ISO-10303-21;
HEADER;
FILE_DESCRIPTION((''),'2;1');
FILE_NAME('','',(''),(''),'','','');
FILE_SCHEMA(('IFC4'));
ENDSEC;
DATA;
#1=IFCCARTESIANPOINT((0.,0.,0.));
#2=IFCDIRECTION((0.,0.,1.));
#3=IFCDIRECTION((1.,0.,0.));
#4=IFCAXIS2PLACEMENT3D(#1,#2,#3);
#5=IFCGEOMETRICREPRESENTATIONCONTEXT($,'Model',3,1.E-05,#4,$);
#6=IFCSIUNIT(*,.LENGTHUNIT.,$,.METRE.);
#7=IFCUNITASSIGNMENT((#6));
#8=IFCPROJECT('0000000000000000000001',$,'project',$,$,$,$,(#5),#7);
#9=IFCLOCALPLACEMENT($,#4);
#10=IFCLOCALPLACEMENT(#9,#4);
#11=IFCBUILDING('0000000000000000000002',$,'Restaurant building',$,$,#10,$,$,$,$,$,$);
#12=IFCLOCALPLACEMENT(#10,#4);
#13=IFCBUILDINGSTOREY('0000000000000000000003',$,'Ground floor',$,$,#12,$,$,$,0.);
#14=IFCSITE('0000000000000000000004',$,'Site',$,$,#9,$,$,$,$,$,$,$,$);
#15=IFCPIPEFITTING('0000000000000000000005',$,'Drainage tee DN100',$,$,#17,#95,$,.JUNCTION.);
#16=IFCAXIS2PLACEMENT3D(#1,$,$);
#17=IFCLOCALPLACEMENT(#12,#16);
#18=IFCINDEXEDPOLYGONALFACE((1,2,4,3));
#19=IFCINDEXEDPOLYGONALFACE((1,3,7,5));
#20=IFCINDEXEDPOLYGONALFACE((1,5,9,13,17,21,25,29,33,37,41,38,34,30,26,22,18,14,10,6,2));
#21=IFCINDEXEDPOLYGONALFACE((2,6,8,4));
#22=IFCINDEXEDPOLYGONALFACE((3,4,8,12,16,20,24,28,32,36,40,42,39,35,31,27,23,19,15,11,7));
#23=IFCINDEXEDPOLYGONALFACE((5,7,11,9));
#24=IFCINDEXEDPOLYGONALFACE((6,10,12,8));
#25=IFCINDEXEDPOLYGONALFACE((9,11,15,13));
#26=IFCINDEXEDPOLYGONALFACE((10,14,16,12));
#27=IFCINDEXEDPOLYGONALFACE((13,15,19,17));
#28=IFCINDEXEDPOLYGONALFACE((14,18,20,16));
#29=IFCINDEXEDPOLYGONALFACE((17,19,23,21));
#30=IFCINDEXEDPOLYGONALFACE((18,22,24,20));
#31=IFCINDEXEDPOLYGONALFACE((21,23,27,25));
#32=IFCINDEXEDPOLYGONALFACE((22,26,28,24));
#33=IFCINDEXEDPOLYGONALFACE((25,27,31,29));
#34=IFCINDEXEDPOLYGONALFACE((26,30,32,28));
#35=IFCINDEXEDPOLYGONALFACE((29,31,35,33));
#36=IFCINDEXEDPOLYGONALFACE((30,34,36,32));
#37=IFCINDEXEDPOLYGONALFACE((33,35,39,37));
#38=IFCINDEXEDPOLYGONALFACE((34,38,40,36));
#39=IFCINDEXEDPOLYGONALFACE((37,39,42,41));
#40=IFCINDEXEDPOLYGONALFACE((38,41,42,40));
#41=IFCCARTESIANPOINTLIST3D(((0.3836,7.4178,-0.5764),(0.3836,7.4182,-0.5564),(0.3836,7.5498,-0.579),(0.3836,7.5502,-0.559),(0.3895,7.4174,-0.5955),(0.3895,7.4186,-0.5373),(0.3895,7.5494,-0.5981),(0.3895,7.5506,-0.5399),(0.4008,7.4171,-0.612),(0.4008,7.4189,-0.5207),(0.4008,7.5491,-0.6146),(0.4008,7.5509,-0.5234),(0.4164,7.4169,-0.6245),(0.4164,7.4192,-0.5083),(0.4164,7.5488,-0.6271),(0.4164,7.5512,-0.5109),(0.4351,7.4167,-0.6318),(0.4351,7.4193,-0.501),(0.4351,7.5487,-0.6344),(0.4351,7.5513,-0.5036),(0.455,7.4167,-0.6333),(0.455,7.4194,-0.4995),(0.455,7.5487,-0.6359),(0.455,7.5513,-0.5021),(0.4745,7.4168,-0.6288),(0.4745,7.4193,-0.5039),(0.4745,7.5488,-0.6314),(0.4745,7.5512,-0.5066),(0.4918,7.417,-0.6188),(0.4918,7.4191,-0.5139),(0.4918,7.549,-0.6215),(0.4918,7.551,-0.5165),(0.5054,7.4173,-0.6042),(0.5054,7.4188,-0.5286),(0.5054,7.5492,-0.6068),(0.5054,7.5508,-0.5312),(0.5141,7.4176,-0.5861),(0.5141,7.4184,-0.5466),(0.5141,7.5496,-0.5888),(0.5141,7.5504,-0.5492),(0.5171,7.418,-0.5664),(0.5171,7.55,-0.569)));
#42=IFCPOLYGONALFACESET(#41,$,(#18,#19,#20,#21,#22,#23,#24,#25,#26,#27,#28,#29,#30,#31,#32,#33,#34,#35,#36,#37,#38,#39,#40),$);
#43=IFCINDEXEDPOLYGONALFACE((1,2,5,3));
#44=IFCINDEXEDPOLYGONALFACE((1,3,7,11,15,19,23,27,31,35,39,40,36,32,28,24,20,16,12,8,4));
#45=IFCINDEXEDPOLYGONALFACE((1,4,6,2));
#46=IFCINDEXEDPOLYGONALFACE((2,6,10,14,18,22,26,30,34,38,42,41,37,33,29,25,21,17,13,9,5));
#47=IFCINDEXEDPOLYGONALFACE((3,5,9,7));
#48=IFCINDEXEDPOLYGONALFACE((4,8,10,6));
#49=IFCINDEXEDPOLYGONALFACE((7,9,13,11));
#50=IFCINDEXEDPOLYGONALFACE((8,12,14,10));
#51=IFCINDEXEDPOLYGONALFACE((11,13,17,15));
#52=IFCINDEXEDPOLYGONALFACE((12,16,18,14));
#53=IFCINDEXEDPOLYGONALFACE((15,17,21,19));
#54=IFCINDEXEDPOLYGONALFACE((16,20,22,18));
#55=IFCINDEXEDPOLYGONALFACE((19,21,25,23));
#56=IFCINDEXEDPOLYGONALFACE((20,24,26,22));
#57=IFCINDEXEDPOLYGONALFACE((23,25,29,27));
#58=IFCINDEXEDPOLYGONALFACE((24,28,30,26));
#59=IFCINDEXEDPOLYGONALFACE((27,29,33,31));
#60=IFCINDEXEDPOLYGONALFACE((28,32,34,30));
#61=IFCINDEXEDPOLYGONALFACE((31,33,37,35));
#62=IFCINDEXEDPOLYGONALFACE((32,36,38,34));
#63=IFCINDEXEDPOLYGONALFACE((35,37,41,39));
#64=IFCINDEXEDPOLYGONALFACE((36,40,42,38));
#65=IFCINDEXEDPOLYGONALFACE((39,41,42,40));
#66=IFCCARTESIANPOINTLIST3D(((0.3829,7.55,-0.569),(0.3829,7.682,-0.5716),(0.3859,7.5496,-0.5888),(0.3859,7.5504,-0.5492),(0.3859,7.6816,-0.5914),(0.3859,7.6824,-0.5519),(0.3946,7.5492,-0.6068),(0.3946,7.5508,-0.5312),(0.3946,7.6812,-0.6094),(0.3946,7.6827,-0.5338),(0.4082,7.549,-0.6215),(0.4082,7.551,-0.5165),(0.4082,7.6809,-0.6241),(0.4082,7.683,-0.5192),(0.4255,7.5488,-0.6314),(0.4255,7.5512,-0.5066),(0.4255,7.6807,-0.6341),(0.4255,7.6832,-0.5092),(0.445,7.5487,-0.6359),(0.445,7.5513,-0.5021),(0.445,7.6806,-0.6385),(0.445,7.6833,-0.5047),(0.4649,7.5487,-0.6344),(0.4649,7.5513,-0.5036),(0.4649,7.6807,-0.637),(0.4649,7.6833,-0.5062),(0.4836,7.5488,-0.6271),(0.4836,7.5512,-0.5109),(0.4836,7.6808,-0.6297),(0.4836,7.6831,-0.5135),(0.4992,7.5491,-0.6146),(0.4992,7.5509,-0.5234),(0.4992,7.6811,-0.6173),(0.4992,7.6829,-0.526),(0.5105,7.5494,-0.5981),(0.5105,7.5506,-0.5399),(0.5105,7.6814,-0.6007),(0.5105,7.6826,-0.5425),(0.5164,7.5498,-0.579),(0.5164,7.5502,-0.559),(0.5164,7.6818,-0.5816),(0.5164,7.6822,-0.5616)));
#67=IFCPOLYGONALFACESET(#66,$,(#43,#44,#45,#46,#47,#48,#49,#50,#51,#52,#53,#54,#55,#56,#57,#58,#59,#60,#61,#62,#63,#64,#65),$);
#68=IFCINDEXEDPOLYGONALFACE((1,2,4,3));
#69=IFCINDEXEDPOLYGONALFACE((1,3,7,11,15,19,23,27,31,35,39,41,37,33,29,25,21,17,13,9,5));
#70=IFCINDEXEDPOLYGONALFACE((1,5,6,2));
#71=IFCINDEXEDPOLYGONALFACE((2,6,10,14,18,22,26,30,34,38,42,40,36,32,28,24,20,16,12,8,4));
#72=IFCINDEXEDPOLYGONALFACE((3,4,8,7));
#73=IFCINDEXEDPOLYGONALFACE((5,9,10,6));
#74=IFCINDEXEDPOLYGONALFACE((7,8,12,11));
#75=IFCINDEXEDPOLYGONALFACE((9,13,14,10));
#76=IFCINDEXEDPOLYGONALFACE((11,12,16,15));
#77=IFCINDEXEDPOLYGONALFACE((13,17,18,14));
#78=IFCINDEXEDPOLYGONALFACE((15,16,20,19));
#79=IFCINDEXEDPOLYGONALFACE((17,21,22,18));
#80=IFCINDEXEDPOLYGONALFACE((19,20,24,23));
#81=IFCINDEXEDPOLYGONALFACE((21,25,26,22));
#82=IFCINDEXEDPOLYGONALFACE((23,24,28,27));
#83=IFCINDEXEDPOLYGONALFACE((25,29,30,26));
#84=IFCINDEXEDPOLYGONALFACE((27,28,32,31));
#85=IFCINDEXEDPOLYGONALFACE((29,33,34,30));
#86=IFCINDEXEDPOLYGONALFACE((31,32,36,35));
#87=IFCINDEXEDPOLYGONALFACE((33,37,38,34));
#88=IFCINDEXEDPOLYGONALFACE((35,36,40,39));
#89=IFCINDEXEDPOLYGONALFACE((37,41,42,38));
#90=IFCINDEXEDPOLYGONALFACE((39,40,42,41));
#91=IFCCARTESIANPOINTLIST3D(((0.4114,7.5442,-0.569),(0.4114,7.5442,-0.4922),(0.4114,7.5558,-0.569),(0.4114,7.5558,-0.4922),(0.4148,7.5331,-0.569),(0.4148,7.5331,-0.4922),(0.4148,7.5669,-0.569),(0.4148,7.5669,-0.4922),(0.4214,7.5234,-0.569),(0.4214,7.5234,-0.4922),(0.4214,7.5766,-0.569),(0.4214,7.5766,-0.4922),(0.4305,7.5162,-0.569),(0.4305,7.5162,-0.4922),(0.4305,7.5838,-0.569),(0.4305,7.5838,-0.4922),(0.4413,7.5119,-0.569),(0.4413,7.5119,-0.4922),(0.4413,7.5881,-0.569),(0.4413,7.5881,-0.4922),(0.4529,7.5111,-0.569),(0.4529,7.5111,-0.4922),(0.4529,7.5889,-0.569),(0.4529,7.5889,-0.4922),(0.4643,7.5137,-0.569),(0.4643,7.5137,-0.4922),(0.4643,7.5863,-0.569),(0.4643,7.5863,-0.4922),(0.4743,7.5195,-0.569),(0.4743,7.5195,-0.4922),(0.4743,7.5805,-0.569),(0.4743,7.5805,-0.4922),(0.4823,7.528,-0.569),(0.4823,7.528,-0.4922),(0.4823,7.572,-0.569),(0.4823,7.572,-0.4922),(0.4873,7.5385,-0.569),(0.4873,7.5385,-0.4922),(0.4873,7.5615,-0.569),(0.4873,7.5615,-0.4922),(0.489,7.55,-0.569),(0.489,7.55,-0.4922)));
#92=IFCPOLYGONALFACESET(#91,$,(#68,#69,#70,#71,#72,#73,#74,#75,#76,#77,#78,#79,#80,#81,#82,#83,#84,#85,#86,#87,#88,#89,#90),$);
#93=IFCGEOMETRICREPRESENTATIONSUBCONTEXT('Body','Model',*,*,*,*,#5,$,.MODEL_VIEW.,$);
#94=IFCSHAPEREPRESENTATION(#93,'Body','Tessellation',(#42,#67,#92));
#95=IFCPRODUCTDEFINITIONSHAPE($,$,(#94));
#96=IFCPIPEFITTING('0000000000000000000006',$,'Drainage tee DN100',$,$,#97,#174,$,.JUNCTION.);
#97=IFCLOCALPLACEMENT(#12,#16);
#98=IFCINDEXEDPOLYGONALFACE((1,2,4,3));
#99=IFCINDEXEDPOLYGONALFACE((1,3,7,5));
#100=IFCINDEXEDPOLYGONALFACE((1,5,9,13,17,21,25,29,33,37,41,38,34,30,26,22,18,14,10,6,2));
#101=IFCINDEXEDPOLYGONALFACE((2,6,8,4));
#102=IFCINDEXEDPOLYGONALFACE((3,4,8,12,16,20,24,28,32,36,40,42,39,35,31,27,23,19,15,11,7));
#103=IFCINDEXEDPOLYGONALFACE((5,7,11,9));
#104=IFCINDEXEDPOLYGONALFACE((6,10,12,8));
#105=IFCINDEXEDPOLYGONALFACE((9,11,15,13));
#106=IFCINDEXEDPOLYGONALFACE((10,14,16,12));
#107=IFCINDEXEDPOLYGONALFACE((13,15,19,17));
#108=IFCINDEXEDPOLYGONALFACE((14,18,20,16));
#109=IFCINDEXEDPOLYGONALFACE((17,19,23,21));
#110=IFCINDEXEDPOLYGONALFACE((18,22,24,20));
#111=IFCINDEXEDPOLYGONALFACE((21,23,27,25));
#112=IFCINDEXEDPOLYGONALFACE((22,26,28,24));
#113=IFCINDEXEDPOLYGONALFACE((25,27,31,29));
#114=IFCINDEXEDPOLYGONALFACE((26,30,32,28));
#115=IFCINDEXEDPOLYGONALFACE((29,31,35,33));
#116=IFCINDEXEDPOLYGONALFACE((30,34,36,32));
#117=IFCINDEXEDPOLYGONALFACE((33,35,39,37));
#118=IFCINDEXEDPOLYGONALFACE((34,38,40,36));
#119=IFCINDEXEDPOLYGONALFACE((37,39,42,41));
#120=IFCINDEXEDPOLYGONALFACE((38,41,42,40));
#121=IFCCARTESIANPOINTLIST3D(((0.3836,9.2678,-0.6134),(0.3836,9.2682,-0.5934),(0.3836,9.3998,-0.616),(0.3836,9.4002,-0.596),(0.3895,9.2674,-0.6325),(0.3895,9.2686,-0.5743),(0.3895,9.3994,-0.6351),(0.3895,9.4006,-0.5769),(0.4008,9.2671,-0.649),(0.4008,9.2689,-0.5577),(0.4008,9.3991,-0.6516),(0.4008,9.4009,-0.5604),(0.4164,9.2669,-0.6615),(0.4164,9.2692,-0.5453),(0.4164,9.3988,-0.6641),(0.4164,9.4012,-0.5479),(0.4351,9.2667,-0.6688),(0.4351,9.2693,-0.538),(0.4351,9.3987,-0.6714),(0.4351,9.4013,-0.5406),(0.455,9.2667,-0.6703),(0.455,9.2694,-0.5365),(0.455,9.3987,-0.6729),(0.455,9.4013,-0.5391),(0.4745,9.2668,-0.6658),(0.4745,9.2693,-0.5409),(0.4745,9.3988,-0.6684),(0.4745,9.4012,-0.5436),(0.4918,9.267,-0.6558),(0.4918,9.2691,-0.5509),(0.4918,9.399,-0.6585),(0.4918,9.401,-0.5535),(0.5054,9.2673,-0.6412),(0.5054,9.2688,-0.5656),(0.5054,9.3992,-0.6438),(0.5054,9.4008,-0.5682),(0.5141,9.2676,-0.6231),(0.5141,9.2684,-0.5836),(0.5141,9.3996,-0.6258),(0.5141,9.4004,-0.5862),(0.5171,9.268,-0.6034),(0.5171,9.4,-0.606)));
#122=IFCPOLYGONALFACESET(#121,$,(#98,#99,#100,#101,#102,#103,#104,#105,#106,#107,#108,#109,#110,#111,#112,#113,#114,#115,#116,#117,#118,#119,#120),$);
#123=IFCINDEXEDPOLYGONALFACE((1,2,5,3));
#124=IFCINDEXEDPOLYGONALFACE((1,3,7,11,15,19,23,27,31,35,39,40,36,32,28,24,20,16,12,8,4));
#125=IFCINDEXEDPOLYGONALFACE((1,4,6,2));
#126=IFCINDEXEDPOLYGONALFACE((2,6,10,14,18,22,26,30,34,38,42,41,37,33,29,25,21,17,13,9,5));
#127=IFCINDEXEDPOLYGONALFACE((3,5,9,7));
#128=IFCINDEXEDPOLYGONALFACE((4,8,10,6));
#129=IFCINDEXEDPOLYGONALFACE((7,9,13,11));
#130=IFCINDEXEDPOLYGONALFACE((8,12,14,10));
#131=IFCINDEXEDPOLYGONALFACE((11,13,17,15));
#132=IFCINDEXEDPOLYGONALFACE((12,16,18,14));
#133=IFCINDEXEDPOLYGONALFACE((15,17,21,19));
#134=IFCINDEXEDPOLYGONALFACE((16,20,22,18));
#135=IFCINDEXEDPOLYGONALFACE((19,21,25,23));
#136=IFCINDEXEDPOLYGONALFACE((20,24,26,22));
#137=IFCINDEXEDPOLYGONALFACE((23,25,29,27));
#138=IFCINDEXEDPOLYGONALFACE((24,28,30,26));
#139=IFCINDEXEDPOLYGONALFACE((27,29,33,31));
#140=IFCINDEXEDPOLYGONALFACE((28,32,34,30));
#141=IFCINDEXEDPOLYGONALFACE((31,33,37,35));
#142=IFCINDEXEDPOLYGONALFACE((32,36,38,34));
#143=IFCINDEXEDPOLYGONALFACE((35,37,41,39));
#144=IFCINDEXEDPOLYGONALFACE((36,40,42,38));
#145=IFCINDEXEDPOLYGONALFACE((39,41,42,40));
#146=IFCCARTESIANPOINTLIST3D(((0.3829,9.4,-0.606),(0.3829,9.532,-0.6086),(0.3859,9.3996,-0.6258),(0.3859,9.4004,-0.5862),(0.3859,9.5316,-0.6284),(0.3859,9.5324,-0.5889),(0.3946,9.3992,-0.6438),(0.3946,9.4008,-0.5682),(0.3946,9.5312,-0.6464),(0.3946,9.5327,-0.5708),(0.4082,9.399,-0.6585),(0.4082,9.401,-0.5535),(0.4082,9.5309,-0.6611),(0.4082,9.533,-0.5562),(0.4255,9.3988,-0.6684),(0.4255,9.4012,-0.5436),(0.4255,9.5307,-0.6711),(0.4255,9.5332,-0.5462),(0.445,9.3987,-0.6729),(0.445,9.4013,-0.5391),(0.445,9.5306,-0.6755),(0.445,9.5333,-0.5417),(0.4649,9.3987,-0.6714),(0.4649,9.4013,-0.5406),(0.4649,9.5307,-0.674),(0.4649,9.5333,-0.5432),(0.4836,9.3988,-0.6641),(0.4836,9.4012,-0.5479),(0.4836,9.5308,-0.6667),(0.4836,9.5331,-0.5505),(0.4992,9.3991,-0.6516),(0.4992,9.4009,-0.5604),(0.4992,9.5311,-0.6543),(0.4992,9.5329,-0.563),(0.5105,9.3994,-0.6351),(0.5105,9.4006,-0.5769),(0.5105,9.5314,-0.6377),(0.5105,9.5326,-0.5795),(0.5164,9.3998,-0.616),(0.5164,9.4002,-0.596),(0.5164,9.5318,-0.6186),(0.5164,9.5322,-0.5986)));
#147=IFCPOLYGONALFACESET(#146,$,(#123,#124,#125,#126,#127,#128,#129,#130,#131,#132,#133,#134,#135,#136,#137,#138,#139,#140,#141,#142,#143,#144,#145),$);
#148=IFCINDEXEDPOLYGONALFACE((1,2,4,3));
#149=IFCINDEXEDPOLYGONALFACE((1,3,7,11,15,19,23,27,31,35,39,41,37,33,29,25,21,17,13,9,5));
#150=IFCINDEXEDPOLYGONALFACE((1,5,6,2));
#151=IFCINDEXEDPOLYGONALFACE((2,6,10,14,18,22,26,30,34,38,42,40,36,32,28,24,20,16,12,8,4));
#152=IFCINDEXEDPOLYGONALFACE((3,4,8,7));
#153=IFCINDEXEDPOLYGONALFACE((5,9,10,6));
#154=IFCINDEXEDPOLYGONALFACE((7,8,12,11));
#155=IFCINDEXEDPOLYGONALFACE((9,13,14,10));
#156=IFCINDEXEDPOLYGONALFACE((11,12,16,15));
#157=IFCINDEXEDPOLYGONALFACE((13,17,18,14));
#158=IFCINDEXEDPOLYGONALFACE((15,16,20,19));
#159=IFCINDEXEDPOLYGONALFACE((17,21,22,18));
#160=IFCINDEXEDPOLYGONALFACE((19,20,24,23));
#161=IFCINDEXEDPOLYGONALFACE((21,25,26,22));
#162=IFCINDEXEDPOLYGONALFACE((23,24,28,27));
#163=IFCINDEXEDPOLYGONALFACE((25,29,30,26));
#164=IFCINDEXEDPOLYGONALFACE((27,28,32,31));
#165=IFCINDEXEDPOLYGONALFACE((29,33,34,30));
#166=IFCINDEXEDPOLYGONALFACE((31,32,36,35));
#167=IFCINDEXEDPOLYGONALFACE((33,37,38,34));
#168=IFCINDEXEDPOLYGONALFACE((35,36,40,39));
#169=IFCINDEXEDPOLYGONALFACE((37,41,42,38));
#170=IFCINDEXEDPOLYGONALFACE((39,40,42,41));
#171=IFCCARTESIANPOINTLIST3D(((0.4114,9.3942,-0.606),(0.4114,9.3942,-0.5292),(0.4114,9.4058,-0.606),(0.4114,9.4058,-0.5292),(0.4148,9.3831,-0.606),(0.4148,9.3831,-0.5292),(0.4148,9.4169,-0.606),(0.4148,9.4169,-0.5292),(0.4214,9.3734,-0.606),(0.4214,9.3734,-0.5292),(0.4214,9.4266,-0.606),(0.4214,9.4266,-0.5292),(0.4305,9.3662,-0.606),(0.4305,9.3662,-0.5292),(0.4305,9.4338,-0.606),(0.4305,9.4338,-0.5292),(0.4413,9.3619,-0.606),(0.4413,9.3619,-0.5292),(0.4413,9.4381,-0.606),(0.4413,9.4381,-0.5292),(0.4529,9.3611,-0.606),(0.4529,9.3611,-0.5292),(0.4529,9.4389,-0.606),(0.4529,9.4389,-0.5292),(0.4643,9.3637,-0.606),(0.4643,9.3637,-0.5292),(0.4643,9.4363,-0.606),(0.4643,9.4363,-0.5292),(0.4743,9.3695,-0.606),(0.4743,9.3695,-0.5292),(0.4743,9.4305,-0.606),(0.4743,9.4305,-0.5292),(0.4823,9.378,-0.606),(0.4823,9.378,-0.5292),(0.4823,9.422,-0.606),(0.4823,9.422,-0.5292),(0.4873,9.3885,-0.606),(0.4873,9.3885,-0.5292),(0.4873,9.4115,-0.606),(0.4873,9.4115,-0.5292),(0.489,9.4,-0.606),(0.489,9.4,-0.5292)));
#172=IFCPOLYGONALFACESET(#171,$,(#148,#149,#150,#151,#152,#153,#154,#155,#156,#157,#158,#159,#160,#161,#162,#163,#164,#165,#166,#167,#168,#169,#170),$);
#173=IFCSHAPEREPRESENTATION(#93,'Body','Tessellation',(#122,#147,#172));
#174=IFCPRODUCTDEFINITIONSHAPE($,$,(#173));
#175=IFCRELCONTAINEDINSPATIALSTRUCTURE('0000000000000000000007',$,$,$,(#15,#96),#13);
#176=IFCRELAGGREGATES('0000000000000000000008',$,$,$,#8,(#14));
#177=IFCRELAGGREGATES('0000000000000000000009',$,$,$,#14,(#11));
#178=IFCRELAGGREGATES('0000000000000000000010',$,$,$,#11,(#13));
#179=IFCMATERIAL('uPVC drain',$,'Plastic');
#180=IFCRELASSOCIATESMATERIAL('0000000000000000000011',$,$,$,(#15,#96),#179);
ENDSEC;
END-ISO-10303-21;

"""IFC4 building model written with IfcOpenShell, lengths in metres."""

from ifc_helpers import new_model, si_unit, frame, origin, origin_with_axes, origin_2d, place, context, subcontext, project, spatial, circle, extrude, material, element, save


model = new_model("IFC4")

# Units and contexts
model_context = context("Model", 3, precision=1e-05, world=origin_with_axes())
body_context = subcontext(model_context, "Body", "Model", "MODEL_VIEW")
ifc_project = project(units=[si_unit("LENGTHUNIT", "METRE")], contexts=[model_context])

# Site, building, storey
site_placement = place(None, origin_with_axes())
site = spatial("IfcSite", under=ifc_project, at=site_placement, Name="Site")
building_placement = place(site_placement, origin_with_axes())
building = spatial("IfcBuilding", under=site, at=building_placement, Name="Restaurant building")
storey_placement = place(building_placement, origin_with_axes())
storey = spatial("IfcBuildingStorey", under=building, at=storey_placement, Name="Ground floor", Elevation=0.0)

# Shared definitions
ifc_material_1 = material(Name="uPVC drain", Category="Plastic")

# Pipe fittings
for number, where, name in (
    (1, (0.45, 7.55, -0.569), "Drainage tee DN100"),
    (2, (0.45, 9.4, -0.606), "Drainage tee DN100"),
):
    element("IfcPipeFitting", number, at=place(storey_placement, frame(where)), inside=storey, material=ifc_material_1, Name=name, PredefinedType="JUNCTION", context=body_context, shape_type="SweptSolid", body=[
        extrude(circle(Radius=0.0671, at=origin_2d()), frame((0.0, 0.0, 0.0), z_axis=(0.0, -0.9998, 0.019996), x_axis=(1.0, 0.0, 0.0)), (0.0, 0.0, 1.0), 0.132),
        extrude(circle(Radius=0.0671, at=origin_2d()), frame((0.0, 0.0, 0.0), z_axis=(0.0, 0.9998, -0.019996), x_axis=(-1.0, 0.0, 0.0)), (0.0, 0.0, 1.0), 0.132),
        extrude(circle(Radius=0.039, at=origin_2d()), origin(), (0.0, 0.0, 1.0), 0.0768),
    ])

save(model, "model.ifc")
